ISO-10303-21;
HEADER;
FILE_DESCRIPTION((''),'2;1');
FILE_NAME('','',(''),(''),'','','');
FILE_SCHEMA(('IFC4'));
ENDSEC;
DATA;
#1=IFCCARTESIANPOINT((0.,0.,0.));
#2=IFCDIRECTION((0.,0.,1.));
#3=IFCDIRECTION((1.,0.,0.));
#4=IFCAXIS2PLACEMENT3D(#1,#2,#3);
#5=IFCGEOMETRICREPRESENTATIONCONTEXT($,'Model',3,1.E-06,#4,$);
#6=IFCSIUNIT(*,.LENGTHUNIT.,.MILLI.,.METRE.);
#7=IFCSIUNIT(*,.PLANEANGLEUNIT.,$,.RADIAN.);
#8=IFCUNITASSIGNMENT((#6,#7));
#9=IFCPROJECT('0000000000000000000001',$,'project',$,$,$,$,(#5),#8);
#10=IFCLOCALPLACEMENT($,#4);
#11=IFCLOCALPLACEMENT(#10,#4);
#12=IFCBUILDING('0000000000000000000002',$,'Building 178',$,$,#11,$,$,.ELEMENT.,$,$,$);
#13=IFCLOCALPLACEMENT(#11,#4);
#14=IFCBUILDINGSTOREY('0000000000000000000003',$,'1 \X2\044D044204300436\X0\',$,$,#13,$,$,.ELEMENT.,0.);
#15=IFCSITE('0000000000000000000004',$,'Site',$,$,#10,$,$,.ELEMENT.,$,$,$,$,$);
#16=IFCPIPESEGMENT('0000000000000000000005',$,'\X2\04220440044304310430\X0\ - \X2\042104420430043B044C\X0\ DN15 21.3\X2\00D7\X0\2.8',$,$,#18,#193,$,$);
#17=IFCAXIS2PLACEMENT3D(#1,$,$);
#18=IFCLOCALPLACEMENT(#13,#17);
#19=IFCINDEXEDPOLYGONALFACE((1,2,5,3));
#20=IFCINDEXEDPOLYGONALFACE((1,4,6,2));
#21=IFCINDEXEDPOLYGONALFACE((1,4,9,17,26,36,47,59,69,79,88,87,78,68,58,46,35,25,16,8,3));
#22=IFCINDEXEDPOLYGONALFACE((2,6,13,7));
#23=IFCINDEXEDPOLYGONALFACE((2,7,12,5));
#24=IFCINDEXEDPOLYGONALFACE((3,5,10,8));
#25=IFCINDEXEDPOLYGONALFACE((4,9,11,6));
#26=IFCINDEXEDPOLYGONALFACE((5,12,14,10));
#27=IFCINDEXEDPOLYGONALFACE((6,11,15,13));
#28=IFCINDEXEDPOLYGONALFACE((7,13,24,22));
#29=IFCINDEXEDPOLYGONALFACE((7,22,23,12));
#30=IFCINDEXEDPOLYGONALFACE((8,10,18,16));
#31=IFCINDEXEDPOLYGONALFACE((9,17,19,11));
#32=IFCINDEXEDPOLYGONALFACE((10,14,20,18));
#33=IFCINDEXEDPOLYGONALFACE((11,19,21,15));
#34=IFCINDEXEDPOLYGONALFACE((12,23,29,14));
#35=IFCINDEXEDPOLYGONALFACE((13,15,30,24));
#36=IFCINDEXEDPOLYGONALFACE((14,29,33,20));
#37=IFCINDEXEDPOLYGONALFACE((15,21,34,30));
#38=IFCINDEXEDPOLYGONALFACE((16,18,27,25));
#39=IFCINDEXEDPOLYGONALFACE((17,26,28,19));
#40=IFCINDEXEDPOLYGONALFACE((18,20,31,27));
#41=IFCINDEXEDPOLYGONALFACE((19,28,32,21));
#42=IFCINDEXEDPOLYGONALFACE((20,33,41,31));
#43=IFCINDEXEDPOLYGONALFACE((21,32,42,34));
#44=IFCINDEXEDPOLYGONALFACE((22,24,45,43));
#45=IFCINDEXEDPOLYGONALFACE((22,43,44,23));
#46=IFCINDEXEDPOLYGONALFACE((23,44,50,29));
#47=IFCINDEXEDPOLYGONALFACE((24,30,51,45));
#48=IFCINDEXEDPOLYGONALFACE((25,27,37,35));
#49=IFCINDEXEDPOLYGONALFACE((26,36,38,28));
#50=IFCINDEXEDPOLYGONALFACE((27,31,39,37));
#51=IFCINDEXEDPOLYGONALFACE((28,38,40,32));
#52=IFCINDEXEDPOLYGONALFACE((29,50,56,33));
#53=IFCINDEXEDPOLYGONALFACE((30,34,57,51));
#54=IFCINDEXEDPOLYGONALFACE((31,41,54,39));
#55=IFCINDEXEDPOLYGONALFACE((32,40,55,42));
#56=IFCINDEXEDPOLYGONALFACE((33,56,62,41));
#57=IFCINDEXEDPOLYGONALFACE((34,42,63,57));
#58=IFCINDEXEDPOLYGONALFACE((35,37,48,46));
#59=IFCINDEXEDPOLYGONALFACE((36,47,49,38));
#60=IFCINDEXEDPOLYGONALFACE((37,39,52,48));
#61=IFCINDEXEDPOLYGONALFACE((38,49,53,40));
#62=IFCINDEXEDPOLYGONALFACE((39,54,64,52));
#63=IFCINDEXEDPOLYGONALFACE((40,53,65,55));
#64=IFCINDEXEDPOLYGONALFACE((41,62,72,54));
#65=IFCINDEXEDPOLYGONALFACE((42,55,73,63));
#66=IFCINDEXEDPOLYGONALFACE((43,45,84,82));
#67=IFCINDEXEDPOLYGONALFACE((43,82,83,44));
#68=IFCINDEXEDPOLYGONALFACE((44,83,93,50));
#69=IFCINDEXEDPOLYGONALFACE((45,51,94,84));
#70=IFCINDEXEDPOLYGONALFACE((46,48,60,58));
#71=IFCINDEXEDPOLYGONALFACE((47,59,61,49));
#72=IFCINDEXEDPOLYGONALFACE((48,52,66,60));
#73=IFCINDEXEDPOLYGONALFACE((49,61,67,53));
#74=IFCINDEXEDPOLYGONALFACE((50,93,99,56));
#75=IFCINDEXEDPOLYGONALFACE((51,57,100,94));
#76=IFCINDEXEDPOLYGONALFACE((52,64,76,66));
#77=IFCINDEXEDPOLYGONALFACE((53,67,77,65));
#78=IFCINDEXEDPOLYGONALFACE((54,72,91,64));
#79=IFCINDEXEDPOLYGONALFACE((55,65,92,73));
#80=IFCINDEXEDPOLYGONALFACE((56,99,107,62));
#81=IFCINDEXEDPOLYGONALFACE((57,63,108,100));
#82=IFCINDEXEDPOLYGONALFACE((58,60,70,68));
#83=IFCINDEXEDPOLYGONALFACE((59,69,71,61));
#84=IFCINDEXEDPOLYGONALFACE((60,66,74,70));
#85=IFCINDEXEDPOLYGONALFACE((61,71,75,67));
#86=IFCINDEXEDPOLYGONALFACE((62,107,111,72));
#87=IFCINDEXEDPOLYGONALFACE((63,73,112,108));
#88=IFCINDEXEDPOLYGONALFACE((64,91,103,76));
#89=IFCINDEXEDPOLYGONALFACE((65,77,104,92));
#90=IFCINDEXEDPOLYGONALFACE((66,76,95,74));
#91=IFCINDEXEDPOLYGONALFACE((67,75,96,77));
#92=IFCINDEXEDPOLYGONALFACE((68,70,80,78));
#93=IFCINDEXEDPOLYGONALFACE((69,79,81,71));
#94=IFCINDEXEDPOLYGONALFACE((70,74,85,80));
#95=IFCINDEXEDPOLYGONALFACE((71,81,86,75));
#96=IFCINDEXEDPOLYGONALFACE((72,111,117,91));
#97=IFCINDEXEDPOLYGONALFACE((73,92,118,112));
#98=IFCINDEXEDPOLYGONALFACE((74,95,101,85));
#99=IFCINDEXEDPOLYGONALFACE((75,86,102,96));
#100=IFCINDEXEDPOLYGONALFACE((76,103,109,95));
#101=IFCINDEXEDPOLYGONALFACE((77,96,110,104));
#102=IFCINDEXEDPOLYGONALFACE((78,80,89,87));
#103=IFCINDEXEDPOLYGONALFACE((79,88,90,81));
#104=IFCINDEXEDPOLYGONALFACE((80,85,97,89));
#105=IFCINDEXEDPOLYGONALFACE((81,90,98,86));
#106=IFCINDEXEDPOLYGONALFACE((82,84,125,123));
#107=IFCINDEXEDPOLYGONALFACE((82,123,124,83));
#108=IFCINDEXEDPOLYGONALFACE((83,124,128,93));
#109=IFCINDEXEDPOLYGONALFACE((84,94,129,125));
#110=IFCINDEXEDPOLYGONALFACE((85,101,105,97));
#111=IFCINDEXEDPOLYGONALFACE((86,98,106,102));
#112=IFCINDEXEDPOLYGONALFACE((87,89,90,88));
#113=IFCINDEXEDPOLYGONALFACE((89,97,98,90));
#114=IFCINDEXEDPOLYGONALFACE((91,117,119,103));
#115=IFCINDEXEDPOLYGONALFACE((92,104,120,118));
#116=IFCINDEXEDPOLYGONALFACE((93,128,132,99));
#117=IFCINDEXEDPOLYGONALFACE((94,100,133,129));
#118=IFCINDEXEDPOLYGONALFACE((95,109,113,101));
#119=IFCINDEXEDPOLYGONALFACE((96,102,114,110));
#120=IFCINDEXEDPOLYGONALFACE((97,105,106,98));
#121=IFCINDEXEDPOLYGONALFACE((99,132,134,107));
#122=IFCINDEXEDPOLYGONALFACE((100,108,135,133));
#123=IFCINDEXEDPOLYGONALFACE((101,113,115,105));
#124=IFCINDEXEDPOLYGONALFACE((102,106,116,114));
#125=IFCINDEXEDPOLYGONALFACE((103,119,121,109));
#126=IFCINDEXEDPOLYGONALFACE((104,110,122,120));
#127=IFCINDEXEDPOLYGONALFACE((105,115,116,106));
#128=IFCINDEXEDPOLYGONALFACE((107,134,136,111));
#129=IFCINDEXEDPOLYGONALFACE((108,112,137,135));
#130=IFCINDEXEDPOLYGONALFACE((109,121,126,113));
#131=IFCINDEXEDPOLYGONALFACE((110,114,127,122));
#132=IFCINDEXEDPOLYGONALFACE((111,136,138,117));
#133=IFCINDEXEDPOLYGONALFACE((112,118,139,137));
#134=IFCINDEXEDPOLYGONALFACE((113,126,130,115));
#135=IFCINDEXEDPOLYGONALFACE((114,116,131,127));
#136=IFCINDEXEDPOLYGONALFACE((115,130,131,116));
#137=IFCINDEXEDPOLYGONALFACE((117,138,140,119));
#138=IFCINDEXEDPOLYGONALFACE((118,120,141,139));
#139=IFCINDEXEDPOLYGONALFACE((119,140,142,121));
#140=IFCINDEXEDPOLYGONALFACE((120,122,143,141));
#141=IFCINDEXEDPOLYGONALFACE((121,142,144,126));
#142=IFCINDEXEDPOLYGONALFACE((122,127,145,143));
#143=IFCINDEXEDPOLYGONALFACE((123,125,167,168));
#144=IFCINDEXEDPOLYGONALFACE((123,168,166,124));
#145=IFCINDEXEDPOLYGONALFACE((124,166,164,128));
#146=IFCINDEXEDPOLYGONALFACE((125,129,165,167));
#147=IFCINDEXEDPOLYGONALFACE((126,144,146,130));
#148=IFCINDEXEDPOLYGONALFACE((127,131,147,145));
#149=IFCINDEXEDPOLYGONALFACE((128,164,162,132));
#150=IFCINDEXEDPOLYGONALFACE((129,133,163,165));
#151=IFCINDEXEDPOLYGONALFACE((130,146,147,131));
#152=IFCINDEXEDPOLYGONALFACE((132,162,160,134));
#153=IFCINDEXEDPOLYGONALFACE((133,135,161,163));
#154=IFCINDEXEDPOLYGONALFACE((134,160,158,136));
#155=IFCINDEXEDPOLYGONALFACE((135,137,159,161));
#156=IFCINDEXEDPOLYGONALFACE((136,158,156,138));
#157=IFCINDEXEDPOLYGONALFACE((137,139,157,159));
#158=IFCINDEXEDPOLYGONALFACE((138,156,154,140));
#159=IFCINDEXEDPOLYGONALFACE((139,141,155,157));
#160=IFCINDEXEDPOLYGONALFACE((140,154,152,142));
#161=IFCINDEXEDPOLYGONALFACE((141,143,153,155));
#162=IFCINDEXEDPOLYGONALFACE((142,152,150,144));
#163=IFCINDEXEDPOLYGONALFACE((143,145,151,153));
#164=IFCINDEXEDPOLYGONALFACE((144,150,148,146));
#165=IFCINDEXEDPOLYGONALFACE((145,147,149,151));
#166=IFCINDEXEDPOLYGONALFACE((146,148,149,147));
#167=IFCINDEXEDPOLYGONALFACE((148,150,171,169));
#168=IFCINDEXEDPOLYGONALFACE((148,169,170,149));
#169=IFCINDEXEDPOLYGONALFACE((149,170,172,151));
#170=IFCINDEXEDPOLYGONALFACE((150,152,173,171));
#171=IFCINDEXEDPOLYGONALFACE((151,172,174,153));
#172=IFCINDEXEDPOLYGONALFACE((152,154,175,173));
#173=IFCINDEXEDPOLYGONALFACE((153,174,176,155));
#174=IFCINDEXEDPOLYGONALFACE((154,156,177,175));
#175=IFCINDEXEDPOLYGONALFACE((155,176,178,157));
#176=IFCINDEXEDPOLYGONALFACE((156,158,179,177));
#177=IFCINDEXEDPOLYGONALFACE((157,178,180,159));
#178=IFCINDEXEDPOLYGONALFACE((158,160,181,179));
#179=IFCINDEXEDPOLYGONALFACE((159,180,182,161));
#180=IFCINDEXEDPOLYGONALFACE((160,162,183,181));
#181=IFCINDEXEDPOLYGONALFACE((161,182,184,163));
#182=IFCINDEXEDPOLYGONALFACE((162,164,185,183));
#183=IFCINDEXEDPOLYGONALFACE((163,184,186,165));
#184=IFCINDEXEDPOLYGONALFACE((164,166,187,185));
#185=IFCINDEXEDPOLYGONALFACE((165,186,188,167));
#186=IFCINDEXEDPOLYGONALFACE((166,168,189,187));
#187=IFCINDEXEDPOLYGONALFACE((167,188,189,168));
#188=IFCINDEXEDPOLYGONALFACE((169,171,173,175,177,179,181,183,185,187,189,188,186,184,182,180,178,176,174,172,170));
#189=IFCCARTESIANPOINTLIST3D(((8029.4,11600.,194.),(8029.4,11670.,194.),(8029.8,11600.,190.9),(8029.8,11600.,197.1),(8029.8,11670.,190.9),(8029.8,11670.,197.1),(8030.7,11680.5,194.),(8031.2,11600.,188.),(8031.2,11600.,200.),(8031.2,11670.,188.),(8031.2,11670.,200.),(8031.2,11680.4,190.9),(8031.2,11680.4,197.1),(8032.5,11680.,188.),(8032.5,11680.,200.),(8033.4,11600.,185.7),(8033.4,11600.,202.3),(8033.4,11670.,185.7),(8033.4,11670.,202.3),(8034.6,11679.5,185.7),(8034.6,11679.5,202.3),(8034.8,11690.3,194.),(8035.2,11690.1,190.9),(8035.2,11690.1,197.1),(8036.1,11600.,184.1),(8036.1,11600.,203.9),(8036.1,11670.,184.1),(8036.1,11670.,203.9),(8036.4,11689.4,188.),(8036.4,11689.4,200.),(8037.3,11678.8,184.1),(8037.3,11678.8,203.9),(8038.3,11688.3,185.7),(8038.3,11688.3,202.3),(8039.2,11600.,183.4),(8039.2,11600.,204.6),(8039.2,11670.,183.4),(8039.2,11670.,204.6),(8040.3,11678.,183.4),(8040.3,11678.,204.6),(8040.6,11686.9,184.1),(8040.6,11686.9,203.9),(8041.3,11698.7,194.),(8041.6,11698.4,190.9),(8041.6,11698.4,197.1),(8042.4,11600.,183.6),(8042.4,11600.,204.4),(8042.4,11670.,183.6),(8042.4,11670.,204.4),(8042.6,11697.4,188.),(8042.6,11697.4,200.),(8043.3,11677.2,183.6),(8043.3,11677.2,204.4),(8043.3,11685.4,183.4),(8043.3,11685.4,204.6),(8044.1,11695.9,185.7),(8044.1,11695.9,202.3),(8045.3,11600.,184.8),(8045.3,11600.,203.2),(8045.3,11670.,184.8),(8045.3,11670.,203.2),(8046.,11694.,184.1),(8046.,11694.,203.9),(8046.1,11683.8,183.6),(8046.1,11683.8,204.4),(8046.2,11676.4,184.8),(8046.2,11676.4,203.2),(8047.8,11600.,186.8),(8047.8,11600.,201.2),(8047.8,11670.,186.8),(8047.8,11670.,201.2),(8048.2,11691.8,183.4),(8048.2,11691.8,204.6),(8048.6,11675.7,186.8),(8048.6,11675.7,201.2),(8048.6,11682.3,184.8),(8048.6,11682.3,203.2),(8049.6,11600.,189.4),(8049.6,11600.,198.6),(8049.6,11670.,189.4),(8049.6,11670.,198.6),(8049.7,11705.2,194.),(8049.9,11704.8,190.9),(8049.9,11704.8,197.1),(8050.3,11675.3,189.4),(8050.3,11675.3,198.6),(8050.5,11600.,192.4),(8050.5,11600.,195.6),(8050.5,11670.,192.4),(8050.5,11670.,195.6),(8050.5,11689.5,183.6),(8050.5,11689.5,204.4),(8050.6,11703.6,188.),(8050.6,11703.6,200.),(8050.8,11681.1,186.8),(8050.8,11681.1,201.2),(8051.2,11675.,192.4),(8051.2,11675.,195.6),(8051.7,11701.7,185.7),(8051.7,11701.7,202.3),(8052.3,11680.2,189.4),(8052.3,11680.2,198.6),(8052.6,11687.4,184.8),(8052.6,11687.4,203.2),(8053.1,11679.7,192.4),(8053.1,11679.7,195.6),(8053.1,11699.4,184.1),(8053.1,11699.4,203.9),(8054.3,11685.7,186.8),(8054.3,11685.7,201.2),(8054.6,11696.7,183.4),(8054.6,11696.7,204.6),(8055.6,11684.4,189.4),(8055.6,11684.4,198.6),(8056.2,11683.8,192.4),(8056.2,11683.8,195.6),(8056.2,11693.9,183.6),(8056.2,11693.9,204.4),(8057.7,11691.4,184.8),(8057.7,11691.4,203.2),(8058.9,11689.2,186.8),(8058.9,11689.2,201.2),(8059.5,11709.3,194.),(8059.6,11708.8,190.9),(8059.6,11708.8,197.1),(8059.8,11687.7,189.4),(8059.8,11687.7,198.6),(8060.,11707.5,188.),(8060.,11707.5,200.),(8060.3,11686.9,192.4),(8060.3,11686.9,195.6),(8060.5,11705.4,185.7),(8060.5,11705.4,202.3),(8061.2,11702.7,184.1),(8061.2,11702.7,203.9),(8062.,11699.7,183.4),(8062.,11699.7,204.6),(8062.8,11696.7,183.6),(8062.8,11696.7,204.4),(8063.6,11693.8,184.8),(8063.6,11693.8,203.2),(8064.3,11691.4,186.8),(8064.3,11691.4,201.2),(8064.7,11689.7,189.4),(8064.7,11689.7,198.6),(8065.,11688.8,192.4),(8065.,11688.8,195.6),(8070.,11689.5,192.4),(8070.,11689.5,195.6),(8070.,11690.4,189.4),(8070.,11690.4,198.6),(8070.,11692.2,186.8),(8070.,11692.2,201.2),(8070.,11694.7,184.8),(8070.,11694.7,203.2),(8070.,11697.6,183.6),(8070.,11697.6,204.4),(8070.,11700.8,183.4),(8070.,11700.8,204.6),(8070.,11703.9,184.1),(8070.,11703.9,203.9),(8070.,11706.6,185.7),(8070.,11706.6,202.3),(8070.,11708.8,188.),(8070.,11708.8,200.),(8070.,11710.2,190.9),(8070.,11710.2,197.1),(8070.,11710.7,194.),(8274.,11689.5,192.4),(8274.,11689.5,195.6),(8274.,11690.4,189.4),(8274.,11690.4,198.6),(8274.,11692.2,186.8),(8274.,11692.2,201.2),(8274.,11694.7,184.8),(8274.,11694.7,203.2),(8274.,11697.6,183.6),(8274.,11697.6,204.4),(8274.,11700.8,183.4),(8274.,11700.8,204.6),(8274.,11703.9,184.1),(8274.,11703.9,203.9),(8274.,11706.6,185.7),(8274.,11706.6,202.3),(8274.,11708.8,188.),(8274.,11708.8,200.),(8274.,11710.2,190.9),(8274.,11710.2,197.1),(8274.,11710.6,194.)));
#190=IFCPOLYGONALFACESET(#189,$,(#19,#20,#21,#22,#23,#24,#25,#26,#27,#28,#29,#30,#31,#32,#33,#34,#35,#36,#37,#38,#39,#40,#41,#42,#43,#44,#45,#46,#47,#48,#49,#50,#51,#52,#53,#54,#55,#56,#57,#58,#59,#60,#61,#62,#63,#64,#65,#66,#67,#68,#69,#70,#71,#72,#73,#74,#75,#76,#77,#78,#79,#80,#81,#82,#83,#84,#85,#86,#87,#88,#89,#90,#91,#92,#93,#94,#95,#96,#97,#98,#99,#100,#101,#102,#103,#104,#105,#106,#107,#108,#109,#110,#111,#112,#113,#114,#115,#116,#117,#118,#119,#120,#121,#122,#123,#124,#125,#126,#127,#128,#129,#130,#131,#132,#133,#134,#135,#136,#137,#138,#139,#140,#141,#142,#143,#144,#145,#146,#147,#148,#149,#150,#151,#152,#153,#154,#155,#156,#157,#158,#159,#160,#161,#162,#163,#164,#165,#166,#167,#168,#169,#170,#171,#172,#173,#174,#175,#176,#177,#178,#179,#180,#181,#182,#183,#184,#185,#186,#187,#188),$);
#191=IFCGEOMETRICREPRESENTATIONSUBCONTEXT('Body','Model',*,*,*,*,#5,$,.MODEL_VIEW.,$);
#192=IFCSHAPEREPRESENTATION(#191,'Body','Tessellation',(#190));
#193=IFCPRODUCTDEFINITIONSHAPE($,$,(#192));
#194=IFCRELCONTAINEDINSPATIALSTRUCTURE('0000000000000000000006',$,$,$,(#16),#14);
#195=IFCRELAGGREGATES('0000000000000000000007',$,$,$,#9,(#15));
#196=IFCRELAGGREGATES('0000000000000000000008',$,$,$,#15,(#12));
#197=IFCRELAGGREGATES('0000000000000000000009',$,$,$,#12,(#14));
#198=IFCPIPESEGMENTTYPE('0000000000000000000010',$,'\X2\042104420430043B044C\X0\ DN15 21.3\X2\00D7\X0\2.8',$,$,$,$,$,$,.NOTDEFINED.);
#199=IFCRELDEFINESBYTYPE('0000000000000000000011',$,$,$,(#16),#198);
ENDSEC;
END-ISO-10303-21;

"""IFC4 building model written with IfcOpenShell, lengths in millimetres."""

from ifc_helpers import new_model, entity, si_unit, frame, origin_with_axes, place, context, subcontext, project, spatial, source, transform, mapped, type_object, element, save


model = new_model("IFC4")

# Units and contexts
model_context = context("Model", 3, precision=1e-06, world=origin_with_axes())
body_context = subcontext(model_context, "Body", "Model", "MODEL_VIEW")
ifc_project = project(units=[si_unit("LENGTHUNIT", "METRE", prefix="MILLI"), si_unit("PLANEANGLEUNIT", "RADIAN")], contexts=[model_context])

# Site, building, storey
site_placement = place(None, origin_with_axes())
site = spatial("IfcSite", under=ifc_project, at=site_placement, Name="Site", CompositionType="ELEMENT")
building_placement = place(site_placement, origin_with_axes())
building = spatial("IfcBuilding", under=site, at=building_placement, Name="Building 178", CompositionType="ELEMENT")
storey_placement = place(building_placement, origin_with_axes())
storey = spatial("IfcBuildingStorey", under=building, at=storey_placement, Name="1 этаж", CompositionType="ELEMENT", Elevation=0.0)

# Pipe segment
pipe_segment_type = type_object("IfcPipeSegmentType", Name="Сталь DN15 21.3×2.8", PredefinedType="NOTDEFINED")
shared_shape_1 = source(origin_with_axes(), body_context, "Body", "AdvancedSweptSolid", [
    entity("IfcSweptDiskSolid", entity("IfcIndexedPolyCurve", entity("IfcCartesianPointList3D", [[0.0, 0.0, 0.0], [0.0, 0.0, -70.0], [8.8, 0.0, -91.2], [30.0, 0.0, -100.0], [234.0, 0.0, -100.0]]), [entity("IfcLineIndex", [1, 2]), entity("IfcArcIndex", [2, 3, 4]), entity("IfcLineIndex", [4, 5])]), 10.7),
])
for number, where, z_axis, x_axis, name in (
    (1, (8040.0, 11600.0, 194.0), (0.0, -1.0, 0.0), (1.0, 0.0, 0.0), "Труба - Сталь DN15 21.3×2.8"),
):
    element("IfcPipeSegment", number, at=place(storey_placement, frame(where, z_axis=z_axis, x_axis=x_axis)), inside=storey, type_object=pipe_segment_type, Name=name, context=body_context, shape_type="MappedRepresentation", body=[
        mapped(shared_shape_1, transform((0.0, 0.0, 0.0), x_axis=(1.0, 0.0, 0.0), y_axis=(0.0, 1.0, 0.0), z_axis=(0.0, 0.0, 1.0), scale=1.0)),
    ])

save(model, "model.ifc")
